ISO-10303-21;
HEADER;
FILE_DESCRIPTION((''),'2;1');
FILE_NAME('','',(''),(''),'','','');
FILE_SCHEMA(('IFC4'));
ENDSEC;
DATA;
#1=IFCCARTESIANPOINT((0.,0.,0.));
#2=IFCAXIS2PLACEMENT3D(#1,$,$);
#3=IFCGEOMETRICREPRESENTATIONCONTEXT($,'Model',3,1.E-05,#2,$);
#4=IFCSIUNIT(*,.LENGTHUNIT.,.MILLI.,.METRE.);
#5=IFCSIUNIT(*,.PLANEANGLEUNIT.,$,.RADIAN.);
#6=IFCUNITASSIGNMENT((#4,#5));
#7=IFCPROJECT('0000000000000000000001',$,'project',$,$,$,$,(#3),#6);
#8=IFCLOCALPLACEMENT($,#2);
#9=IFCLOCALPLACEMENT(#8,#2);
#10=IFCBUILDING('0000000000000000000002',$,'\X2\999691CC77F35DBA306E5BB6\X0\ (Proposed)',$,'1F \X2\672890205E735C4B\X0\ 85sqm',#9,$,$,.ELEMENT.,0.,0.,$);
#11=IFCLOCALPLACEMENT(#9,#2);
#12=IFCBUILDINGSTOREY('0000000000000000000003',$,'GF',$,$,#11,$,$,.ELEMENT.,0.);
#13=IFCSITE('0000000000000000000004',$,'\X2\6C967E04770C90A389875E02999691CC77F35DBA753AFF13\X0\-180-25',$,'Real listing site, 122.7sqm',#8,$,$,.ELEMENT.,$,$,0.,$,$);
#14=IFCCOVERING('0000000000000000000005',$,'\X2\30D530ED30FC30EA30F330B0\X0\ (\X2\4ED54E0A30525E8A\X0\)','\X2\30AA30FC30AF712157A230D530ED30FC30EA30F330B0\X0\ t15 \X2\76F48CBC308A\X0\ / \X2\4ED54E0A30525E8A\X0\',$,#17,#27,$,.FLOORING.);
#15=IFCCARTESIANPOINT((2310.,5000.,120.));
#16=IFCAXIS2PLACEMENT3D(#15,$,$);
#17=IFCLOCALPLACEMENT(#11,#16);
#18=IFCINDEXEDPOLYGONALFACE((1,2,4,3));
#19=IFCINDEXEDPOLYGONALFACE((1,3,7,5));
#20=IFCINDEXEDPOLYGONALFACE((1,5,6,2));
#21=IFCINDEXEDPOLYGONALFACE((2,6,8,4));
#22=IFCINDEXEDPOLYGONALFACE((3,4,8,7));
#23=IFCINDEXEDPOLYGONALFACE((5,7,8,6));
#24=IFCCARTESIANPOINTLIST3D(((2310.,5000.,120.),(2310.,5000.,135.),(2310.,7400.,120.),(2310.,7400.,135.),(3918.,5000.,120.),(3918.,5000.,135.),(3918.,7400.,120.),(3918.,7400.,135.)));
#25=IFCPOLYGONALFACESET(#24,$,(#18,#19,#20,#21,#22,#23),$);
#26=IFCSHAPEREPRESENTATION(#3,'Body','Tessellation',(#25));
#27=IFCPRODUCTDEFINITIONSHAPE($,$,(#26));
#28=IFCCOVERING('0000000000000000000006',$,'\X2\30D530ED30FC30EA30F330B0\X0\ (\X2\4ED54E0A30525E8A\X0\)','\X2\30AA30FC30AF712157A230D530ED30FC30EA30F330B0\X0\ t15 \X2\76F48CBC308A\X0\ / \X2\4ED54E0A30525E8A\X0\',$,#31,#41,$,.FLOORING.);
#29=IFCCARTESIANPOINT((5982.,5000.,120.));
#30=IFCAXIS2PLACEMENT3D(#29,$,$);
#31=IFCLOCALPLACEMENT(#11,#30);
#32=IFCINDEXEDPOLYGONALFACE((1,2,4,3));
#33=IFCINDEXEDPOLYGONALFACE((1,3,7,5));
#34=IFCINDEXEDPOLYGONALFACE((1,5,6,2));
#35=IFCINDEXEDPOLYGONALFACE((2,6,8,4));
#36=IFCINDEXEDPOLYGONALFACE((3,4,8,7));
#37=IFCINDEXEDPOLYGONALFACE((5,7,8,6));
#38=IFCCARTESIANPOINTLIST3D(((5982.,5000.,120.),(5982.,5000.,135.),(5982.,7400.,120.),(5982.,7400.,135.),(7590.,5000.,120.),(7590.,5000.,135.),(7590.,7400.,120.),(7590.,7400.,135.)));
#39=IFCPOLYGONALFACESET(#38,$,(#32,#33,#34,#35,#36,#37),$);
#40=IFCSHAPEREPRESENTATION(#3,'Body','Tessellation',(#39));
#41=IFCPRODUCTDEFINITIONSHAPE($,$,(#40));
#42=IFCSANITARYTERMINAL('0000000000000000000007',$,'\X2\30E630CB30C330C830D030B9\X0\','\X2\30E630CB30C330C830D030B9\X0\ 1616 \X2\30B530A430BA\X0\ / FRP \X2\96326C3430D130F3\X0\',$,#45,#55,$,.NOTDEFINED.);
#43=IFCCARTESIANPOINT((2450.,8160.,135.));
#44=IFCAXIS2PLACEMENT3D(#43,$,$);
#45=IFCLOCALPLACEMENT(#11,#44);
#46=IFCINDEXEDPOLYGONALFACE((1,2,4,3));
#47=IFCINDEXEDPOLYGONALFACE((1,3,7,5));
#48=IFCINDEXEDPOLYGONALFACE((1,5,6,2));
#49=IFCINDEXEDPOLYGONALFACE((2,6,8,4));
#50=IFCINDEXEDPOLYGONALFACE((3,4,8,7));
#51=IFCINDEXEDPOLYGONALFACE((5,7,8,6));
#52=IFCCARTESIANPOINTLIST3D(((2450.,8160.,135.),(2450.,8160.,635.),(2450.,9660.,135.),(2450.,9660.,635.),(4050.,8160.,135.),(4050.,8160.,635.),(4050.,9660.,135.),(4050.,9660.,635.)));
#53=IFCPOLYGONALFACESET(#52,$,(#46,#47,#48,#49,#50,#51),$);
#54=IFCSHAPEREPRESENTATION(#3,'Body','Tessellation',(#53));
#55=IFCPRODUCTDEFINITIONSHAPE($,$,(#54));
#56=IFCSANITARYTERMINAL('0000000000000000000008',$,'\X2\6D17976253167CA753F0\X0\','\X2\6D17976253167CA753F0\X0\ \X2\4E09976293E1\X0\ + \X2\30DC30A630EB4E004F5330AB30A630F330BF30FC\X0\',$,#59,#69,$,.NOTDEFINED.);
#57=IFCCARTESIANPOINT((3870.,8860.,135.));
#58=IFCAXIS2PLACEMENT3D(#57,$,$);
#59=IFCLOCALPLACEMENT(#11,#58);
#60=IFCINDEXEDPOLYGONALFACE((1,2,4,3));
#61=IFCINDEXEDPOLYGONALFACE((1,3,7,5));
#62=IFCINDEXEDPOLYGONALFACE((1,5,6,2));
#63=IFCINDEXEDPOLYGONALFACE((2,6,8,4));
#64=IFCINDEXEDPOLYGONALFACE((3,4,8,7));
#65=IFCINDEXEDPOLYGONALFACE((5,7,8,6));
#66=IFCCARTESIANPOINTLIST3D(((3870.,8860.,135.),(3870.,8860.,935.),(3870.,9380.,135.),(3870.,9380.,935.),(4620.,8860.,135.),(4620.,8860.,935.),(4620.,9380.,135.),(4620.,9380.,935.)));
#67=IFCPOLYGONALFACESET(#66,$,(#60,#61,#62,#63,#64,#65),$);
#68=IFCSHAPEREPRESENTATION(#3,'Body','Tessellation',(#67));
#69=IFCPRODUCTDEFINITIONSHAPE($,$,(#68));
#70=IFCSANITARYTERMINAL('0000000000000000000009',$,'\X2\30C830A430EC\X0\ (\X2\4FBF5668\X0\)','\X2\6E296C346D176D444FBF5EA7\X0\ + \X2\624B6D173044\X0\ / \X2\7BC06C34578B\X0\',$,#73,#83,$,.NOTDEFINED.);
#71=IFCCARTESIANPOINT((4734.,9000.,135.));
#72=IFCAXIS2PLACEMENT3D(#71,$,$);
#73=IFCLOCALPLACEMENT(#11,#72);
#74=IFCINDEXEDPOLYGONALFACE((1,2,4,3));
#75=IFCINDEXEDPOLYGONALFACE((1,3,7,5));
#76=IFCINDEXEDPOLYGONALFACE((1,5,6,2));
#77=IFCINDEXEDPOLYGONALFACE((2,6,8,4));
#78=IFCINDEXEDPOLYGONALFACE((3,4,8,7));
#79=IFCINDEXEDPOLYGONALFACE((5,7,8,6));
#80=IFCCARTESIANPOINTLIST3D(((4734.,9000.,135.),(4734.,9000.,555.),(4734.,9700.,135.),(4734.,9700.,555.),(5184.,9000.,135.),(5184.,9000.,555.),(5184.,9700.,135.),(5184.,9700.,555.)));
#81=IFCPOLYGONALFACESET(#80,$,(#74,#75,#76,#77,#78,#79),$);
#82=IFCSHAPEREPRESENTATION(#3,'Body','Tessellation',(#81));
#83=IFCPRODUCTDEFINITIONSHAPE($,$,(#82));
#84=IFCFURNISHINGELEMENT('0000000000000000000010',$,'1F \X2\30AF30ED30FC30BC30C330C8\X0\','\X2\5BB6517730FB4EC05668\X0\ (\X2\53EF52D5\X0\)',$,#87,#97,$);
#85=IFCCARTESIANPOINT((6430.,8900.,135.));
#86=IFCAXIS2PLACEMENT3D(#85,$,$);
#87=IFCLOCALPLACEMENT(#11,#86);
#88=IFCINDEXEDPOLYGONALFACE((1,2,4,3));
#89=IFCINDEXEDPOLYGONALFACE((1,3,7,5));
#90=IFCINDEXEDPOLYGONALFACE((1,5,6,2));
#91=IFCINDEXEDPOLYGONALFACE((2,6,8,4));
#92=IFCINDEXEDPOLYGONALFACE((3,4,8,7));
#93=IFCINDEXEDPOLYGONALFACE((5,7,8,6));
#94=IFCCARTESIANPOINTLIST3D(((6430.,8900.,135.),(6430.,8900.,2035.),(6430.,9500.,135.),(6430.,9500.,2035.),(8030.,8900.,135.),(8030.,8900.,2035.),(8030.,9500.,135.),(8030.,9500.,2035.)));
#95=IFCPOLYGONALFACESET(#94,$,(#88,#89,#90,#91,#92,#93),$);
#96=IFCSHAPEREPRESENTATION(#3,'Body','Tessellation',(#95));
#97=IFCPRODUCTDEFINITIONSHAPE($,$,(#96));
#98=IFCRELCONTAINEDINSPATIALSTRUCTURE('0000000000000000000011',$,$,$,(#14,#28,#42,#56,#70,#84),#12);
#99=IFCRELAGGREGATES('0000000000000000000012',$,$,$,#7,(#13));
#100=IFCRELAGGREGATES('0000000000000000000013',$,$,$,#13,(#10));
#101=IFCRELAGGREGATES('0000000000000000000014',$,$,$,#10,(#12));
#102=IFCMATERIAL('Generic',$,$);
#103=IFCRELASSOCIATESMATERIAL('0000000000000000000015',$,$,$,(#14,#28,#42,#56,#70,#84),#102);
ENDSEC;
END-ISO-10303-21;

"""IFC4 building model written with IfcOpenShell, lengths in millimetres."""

from ifc_helpers import new_model, si_unit, frame, frame_2d, origin, place, context, project, spatial, rectangle, extrude, material, element, save


model = new_model("IFC4")

# Units and contexts
model_context = context("Model", 3, precision=1e-05, world=origin())
ifc_project = project(units=[si_unit("LENGTHUNIT", "METRE", prefix="MILLI"), si_unit("PLANEANGLEUNIT", "RADIAN")], contexts=[model_context])

# Site, building, storey
site_placement = place(None, origin())
site = spatial("IfcSite", under=ifc_project, at=site_placement, Name="沖縄県那覇市首里石嶺町３-180-25", ObjectType="Real listing site, 122.7sqm", CompositionType="ELEMENT", RefElevation=0.0)
building_placement = place(site_placement, origin())
building = spatial("IfcBuilding", under=site, at=building_placement, Name="首里石嶺の家 (Proposed)", ObjectType="1F 木造平屋 85sqm", CompositionType="ELEMENT", ElevationOfRefHeight=0.0, ElevationOfTerrain=0.0)
storey_placement = place(building_placement, origin())
storey = spatial("IfcBuildingStorey", under=building, at=storey_placement, Name="GF", CompositionType="ELEMENT", Elevation=0.0)

# Coverings
ifc_material_1 = material(Name="Generic")
covering_1_placement = place(storey_placement, frame((2310.0, 5000.0, 120.0)))
element("IfcCovering", 1, at=covering_1_placement, inside=storey, material=ifc_material_1, Name="フローリング (仕上げ床)", Description="オーク無垢フローリング t15 直貼り / 仕上げ床", PredefinedType="FLOORING", context=model_context, shape_type="SweptSolid", body=[
    extrude(rectangle(XDim=1608.0, YDim=2400.0, at=frame_2d((804.0, 1200.0))), frame((2310.0, 5000.0, 120.0)), (0.0, 0.0, 1.0), 15.0),
])
covering_2_placement = place(storey_placement, frame((5982.0, 5000.0, 120.0)))
element("IfcCovering", 2, at=covering_2_placement, inside=storey, material=ifc_material_1, Name="フローリング (仕上げ床)", Description="オーク無垢フローリング t15 直貼り / 仕上げ床", PredefinedType="FLOORING", context=model_context, shape_type="SweptSolid", body=[
    extrude(rectangle(XDim=1608.0, YDim=2400.0, at=frame_2d((804.0, 1200.0))), frame((5982.0, 5000.0, 120.0)), (0.0, 0.0, 1.0), 15.0),
])

# Sanitary terminals
sanitary_terminal_1_placement = place(storey_placement, frame((2450.0, 8160.0, 135.0)))
element("IfcSanitaryTerminal", 3, at=sanitary_terminal_1_placement, inside=storey, material=ifc_material_1, Name="ユニットバス", Description="ユニットバス 1616 サイズ / FRP 防水パン", PredefinedType="NOTDEFINED", context=model_context, shape_type="SweptSolid", body=[
    extrude(rectangle(XDim=1600.0, YDim=1500.0, at=frame_2d((800.0, 750.0))), frame((2450.0, 8160.0, 135.0)), (0.0, 0.0, 1.0), 500.0),
])
sanitary_terminal_2_placement = place(storey_placement, frame((3870.0, 8860.0, 135.0)))
element("IfcSanitaryTerminal", 4, at=sanitary_terminal_2_placement, inside=storey, material=ifc_material_1, Name="洗面化粧台", Description="洗面化粧台 三面鏡 + ボウル一体カウンター", PredefinedType="NOTDEFINED", context=model_context, shape_type="SweptSolid", body=[
    extrude(rectangle(XDim=750.0, YDim=520.0, at=frame_2d((375.0, 260.0))), frame((3870.0, 8860.0, 135.0)), (0.0, 0.0, 1.0), 800.0),
])
sanitary_terminal_3_placement = place(storey_placement, frame((4734.0, 9000.0, 135.0)))
element("IfcSanitaryTerminal", 5, at=sanitary_terminal_3_placement, inside=storey, material=ifc_material_1, Name="トイレ (便器)", Description="温水洗浄便座 + 手洗い / 節水型", PredefinedType="NOTDEFINED", context=model_context, shape_type="SweptSolid", body=[
    extrude(rectangle(XDim=450.0, YDim=700.0, at=frame_2d((225.0, 350.0))), frame((4734.0, 9000.0, 135.0)), (0.0, 0.0, 1.0), 420.0),
])

# Furnishing element
furnishing_placement = place(storey_placement, frame((6430.0, 8900.0, 135.0)))
element("IfcFurnishingElement", 6, at=furnishing_placement, inside=storey, material=ifc_material_1, Name="1F クローゼット", Description="家具・什器 (可動)", context=model_context, shape_type="SweptSolid", body=[
    extrude(rectangle(XDim=1600.0, YDim=600.0, at=frame_2d((800.0, 300.0))), frame((6430.0, 8900.0, 135.0)), (0.0, 0.0, 1.0), 1900.0),
])

save(model, "model.ifc")
